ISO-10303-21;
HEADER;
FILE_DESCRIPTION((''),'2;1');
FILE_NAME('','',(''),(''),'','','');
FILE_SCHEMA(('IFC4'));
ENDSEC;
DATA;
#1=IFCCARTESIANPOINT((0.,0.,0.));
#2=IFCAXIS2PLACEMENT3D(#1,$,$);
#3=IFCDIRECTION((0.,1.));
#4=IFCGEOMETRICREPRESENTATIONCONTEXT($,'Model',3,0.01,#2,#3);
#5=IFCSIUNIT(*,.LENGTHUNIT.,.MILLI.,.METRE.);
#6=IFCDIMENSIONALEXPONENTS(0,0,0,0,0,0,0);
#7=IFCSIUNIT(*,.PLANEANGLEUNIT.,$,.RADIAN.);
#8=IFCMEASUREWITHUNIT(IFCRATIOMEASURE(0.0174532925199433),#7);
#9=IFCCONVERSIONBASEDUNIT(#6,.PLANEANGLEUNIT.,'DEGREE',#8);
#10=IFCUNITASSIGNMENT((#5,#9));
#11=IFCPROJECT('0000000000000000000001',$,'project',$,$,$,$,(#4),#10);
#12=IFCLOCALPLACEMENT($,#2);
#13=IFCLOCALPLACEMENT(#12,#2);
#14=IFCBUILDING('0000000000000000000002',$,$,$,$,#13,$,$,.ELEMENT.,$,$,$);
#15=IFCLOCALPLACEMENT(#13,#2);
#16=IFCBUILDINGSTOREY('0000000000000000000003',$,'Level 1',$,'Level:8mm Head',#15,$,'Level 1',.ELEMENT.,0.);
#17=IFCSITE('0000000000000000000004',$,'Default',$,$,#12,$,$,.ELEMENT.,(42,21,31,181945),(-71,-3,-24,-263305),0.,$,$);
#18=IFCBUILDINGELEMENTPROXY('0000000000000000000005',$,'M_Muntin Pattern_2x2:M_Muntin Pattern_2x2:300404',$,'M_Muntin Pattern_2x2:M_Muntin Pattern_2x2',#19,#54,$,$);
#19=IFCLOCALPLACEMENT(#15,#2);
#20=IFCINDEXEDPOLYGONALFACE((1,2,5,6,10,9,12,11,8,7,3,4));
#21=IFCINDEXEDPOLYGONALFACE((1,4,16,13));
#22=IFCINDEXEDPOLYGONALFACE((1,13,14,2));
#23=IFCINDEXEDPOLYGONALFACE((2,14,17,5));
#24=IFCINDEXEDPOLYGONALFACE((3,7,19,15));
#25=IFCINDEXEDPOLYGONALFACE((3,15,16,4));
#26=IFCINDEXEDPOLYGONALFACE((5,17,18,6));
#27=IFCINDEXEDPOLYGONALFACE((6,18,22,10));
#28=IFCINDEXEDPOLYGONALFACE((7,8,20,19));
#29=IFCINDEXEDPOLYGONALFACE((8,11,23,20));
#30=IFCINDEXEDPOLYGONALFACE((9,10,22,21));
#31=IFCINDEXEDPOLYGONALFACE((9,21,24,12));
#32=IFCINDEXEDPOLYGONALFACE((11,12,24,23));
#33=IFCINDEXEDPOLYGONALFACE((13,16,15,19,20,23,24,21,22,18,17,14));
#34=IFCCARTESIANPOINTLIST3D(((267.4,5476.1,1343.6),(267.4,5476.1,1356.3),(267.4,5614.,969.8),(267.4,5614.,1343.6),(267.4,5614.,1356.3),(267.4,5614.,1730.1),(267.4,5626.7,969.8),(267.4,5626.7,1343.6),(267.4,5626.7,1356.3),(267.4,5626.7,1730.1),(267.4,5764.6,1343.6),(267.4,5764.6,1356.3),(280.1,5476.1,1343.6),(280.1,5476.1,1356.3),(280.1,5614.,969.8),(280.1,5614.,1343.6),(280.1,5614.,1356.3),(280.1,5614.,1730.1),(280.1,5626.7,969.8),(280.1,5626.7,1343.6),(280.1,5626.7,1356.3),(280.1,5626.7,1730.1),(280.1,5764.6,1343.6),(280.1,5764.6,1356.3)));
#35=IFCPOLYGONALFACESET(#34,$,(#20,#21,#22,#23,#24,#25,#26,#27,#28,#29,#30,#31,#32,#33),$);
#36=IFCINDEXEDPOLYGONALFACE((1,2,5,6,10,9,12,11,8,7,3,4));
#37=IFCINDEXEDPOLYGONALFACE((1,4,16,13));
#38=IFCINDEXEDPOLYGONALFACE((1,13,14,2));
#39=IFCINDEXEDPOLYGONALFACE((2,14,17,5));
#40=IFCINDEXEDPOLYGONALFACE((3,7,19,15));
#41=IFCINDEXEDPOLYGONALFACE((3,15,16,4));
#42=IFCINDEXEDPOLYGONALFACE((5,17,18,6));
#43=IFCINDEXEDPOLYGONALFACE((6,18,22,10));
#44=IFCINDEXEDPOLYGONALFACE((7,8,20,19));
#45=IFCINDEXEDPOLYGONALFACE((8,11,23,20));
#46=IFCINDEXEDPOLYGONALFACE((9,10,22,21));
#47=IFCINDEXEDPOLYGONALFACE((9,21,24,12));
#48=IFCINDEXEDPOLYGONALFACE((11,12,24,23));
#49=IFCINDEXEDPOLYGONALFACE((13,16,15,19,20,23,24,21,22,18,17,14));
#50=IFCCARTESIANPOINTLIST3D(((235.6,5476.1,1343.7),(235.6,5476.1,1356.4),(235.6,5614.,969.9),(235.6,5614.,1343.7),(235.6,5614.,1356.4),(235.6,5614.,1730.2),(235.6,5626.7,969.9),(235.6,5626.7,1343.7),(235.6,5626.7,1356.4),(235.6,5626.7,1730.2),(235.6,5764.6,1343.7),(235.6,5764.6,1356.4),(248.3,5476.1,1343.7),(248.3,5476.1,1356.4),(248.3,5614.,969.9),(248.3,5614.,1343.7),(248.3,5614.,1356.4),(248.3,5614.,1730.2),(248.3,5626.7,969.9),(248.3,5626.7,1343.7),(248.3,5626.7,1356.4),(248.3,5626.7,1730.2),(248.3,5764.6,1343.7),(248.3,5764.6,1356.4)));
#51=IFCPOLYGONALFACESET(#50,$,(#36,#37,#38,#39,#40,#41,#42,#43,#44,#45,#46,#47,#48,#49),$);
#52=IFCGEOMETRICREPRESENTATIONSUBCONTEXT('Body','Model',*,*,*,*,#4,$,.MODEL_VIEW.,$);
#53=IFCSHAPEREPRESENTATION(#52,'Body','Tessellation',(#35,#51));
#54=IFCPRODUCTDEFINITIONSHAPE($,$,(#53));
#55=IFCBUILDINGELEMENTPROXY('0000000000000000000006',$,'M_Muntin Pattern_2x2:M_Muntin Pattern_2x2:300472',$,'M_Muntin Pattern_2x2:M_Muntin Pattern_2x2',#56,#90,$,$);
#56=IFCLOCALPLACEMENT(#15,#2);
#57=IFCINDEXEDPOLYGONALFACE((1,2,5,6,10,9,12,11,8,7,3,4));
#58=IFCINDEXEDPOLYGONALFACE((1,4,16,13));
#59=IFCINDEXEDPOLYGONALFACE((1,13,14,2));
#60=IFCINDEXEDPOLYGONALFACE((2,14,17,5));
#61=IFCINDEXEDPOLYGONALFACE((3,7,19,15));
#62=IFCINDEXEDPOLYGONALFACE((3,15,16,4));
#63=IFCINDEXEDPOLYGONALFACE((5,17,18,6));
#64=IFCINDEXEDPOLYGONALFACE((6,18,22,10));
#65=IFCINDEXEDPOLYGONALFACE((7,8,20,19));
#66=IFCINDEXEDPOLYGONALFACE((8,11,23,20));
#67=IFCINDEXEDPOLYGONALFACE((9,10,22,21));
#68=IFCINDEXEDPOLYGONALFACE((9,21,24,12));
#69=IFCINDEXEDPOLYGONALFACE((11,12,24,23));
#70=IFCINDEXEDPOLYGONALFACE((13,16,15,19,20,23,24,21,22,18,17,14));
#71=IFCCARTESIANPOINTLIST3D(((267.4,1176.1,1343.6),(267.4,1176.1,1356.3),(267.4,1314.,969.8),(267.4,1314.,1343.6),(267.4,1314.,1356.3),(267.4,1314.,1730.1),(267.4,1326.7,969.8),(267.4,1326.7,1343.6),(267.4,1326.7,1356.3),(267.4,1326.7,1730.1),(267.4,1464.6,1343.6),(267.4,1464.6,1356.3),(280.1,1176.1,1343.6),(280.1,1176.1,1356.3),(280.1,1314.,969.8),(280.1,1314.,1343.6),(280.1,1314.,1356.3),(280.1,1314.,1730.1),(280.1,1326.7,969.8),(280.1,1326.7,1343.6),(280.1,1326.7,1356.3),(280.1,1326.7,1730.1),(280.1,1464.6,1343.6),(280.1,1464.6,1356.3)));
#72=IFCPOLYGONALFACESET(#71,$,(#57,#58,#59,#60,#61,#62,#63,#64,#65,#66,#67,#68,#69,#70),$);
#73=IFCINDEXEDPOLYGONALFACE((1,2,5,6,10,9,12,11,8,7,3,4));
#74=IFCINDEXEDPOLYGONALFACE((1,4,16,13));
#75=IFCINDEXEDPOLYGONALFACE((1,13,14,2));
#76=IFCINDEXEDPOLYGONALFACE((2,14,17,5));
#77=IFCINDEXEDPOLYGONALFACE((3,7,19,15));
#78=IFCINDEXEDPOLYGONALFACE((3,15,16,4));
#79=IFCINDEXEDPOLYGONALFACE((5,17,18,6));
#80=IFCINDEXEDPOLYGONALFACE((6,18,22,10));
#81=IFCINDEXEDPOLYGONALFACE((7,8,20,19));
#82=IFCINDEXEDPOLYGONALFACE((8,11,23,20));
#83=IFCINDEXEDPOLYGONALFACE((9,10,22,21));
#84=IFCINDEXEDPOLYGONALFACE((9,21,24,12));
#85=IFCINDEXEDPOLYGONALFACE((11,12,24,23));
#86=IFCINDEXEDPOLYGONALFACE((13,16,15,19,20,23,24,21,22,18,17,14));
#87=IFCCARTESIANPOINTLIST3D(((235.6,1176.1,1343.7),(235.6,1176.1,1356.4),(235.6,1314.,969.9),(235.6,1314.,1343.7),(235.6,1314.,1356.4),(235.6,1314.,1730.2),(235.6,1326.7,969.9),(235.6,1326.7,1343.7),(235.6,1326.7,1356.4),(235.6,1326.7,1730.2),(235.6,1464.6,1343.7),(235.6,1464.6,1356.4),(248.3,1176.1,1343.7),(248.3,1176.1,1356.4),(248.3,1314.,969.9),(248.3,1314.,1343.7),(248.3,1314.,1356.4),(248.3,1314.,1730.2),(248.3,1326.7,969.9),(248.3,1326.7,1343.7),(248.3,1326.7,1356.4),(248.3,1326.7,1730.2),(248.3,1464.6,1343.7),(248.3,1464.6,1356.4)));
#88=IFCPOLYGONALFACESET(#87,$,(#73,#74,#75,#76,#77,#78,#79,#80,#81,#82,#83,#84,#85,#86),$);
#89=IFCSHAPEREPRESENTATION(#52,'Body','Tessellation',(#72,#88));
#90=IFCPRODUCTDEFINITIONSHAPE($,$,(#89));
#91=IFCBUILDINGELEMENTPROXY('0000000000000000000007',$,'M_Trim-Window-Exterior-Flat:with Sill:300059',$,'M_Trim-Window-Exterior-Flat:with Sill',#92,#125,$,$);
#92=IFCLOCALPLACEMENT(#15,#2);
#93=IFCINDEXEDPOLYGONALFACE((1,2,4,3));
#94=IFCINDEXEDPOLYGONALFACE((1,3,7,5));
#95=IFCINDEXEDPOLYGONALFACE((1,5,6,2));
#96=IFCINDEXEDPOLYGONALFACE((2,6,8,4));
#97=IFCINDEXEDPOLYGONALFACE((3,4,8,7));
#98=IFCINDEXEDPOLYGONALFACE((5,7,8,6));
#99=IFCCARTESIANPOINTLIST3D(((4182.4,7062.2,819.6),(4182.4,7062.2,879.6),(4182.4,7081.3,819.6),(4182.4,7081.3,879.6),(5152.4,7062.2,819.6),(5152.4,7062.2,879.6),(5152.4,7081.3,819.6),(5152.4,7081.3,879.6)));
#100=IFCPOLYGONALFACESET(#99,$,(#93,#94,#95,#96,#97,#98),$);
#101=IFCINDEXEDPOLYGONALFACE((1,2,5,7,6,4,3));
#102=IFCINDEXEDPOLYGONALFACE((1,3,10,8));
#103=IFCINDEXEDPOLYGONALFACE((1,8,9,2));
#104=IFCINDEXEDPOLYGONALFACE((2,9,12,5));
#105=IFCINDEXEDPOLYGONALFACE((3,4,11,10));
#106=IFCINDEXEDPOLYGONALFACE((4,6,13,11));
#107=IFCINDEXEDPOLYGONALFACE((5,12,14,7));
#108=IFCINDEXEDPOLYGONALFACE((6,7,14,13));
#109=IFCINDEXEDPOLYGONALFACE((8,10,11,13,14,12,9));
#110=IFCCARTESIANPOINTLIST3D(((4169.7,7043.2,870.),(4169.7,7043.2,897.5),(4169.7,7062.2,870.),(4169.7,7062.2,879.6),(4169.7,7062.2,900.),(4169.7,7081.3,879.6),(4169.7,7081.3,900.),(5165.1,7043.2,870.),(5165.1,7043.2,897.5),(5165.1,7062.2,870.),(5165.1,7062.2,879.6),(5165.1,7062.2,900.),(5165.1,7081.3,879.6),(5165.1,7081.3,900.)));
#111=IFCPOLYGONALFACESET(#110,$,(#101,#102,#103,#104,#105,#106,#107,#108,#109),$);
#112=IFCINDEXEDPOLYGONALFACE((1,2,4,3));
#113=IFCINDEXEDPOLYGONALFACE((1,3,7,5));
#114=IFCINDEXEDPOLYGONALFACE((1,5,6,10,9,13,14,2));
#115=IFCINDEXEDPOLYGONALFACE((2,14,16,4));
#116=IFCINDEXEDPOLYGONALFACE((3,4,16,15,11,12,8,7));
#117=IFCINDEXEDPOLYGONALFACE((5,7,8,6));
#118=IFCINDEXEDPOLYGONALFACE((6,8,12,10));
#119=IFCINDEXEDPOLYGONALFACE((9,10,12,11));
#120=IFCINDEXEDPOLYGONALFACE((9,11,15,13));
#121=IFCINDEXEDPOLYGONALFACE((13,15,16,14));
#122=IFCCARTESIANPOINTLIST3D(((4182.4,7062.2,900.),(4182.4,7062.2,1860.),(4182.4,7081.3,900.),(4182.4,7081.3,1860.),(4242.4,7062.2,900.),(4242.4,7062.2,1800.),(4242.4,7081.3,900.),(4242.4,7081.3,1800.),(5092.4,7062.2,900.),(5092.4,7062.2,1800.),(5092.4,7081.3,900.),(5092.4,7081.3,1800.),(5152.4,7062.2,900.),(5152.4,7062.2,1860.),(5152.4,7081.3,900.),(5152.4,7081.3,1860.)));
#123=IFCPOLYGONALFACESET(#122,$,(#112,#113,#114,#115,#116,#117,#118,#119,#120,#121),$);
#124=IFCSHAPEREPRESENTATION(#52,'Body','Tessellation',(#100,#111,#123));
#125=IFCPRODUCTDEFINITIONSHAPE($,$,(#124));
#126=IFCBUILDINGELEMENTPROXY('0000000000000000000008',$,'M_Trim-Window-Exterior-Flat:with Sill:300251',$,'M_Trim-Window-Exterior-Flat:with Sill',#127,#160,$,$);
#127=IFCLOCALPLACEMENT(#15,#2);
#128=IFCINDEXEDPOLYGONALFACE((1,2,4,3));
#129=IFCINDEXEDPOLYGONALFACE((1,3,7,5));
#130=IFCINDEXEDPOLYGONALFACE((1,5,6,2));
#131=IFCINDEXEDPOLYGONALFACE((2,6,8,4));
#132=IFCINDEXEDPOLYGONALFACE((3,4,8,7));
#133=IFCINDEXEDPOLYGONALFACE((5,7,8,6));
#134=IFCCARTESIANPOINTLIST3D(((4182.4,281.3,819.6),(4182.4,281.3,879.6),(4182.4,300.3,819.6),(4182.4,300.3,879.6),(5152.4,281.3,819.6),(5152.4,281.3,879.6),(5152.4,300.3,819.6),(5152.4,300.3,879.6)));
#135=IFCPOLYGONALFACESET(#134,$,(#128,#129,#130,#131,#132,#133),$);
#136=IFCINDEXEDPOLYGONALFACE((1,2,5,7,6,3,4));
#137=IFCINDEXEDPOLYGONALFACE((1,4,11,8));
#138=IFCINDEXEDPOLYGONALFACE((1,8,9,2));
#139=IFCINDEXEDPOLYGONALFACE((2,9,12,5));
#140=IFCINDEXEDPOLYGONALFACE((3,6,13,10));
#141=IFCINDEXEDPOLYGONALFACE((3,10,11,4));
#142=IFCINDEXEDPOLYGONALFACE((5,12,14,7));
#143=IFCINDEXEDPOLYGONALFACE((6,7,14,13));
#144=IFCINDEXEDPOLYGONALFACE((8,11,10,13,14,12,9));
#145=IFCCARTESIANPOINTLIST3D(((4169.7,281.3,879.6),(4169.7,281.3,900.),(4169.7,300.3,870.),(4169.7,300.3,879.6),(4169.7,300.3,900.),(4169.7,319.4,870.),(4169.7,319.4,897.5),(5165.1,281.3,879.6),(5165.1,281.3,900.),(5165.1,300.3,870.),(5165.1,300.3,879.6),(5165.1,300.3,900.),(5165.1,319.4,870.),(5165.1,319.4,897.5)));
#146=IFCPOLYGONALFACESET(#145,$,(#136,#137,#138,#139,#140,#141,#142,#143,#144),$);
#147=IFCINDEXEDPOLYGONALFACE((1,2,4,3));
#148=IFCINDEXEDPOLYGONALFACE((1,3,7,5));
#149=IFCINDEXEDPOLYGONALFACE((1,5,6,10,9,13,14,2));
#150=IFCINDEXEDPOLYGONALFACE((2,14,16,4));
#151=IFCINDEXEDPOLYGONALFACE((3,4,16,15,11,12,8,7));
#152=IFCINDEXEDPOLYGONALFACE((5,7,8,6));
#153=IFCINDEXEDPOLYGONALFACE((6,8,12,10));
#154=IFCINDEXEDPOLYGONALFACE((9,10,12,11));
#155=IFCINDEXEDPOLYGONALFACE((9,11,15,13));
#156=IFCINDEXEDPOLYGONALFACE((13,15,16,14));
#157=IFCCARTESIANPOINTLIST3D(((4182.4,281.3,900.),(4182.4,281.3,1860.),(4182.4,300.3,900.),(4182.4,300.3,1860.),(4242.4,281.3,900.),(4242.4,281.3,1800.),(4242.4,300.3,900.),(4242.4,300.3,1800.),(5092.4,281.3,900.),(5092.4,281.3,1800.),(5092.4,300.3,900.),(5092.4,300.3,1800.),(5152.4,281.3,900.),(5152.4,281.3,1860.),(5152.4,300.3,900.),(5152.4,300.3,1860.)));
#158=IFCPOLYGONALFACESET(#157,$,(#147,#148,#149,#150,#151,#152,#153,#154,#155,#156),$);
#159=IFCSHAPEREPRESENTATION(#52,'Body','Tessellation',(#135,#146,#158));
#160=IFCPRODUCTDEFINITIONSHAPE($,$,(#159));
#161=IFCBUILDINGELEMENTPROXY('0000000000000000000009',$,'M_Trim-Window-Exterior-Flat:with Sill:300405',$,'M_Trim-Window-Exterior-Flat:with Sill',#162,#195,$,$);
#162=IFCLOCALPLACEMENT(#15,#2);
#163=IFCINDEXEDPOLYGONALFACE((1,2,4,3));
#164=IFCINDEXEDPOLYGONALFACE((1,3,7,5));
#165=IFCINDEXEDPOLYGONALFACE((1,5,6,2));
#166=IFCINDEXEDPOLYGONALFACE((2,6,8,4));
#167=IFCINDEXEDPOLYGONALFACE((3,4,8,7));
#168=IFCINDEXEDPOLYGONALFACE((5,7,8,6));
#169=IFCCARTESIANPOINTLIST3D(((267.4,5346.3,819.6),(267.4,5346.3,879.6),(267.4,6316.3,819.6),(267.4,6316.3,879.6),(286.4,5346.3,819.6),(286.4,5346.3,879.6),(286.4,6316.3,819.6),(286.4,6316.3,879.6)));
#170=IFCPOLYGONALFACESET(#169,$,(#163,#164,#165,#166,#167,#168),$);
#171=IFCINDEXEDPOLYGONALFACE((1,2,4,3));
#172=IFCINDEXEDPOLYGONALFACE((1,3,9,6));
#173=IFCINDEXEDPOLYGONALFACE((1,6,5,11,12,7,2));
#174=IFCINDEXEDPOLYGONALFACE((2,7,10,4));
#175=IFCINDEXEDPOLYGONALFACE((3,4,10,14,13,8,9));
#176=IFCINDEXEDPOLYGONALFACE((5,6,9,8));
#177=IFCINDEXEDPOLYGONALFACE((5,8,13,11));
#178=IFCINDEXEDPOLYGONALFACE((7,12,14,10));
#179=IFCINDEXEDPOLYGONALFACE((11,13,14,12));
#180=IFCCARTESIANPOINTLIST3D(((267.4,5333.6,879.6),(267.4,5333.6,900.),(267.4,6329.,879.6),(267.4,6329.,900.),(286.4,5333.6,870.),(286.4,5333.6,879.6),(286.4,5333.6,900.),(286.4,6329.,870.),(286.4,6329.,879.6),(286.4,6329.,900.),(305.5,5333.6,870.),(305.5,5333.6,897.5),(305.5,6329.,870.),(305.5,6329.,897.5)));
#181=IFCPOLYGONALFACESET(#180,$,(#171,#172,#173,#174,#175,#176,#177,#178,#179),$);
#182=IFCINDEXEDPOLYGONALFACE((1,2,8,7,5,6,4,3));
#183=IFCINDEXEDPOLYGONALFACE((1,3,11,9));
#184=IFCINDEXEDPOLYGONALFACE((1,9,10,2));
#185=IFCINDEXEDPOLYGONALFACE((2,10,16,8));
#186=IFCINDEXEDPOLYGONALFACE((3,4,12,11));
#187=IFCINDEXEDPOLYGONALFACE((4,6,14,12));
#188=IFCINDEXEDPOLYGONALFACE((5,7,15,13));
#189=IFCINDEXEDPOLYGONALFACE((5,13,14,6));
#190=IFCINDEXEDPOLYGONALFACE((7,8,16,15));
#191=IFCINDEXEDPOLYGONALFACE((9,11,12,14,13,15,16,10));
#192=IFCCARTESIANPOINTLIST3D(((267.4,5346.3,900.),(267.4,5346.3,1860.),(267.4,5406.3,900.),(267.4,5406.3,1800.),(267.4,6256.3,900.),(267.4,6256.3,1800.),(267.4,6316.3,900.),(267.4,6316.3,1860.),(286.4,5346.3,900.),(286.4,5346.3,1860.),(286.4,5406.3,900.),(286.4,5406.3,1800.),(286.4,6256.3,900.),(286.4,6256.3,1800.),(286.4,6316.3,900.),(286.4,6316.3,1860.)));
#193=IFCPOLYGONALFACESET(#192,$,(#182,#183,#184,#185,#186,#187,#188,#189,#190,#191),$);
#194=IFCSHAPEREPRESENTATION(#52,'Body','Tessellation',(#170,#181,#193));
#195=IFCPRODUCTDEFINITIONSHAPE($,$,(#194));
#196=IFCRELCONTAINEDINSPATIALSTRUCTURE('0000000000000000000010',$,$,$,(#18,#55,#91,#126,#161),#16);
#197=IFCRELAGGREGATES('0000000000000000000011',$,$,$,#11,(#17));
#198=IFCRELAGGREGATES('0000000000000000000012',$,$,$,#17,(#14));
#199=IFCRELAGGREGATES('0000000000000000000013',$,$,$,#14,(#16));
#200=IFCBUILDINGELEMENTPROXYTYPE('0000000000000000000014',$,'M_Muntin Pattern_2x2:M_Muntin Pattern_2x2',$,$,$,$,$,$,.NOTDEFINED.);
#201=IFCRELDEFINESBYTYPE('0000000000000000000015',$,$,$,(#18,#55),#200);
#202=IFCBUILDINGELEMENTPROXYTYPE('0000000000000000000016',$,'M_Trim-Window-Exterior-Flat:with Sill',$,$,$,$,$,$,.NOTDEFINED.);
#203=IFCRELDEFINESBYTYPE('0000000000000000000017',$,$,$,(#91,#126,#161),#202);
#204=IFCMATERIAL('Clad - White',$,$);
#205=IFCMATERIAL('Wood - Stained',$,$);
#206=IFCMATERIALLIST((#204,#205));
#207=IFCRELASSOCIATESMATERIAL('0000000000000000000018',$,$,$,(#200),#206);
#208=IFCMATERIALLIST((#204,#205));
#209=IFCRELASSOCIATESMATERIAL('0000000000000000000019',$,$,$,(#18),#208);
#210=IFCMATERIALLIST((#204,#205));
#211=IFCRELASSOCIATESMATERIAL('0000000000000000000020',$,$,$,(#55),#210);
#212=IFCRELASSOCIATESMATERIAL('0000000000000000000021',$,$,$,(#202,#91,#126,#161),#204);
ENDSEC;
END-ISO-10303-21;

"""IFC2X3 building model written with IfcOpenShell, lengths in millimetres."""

from ifc_helpers import new_model, entity, si_unit, converted_unit, direction, frame, frame_2d, origin, place, context, subcontext, project, spatial, polyline, rectangle, outline, extrude, source, transform, mapped, material, material_list, type_object, type_shapes, element, save


model = new_model("IFC2X3")

# Units and contexts
model_context = context("Model", 3, precision=0.01, world=origin(), true_north=direction((0.0, 1.0)))
body_context = subcontext(model_context, "Body", "Model", "MODEL_VIEW")
ifc_project = project(units=[si_unit("LENGTHUNIT", "METRE", prefix="MILLI"), converted_unit("PLANEANGLEUNIT", "DEGREE", entity("IfcRatioMeasure", 0.0174532925199433), si_unit("PLANEANGLEUNIT", "RADIAN"), dimensions=[0, 0, 0, 0, 0, 0, 0])], contexts=[model_context])

# Site, building, storey
site_placement = place(None, origin())
site = spatial("IfcSite", under=ifc_project, at=site_placement, Name="Default", CompositionType="ELEMENT", RefLatitude=(42, 21, 31, 181945), RefLongitude=(-71, -3, -24, -263305), RefElevation=0.0)
building_placement = place(site_placement, origin())
building = spatial("IfcBuilding", under=site, at=building_placement, CompositionType="ELEMENT")
storey_placement = place(building_placement, origin())
storey = spatial("IfcBuildingStorey", under=building, at=storey_placement, Name="Level 1", ObjectType="Level:8mm Head", LongName="Level 1", CompositionType="ELEMENT", Elevation=0.0)

# Building element proxies
ifc_material_1 = material(Name="Clad - White")
ifc_material_2 = material(Name="Wood - Stained")
ifc_material_list_1 = material_list([ifc_material_1, ifc_material_2])
building_element_proxy_type_1 = type_object("IfcBuildingElementProxyType", Name="M_Muntin Pattern_2x2:M_Muntin Pattern_2x2", PredefinedType="NOTDEFINED", material=ifc_material_list_1)
shared_shape_1 = source(origin(), body_context, "Body", "SweptSolid", [
    extrude(outline(polyline([(6.4, -6.4), (380.1, -6.4), (380.1, 6.3), (6.4, 6.3), (6.4, 144.2), (-6.3, 144.2), (-6.3, 6.3), (-380.2, 6.3), (-380.2, -6.4), (-6.3, -6.4), (-6.3, -144.2), (6.4, -144.2), (6.4, -6.4)])), frame((0.0, -22.2, 380.1), z_axis=(0.0, 1.0, 0.0), x_axis=(0.0, 0.0, 1.0)), (0.0, 0.0, 1.0), 12.7),
    extrude(outline(polyline([(6.4, -6.4), (380.2, -6.4), (380.2, 6.3), (6.4, 6.3), (6.4, 144.2), (-6.3, 144.2), (-6.3, 6.3), (-380.2, 6.3), (-380.2, -6.4), (-6.3, -6.4), (-6.3, -144.2), (6.4, -144.2), (6.4, -6.4)])), frame((0.0, 9.5, 380.2), z_axis=(0.0, 1.0, 0.0), x_axis=(0.0, 0.0, 1.0)), (0.0, 0.0, 1.0), 12.7),
])
type_shapes(building_element_proxy_type_1, [shared_shape_1])
ifc_material_list_2 = material_list([ifc_material_1, ifc_material_2])
proxy_1_placement = place(storey_placement, frame((257.9, 5620.4, 969.9), z_axis=(0.0, 0.0, 1.0), x_axis=(0.0, 1.0, 0.0)))
element("IfcBuildingElementProxy", 1, at=proxy_1_placement, inside=storey, type_object=building_element_proxy_type_1, material=ifc_material_list_2, Name="M_Muntin Pattern_2x2:M_Muntin Pattern_2x2:300404", ObjectType="M_Muntin Pattern_2x2:M_Muntin Pattern_2x2", context=body_context, shape_type="MappedRepresentation", body=[
    mapped(shared_shape_1, transform((0.0, 0.0, 0.0), scale=1.0)),
])
ifc_material_list_3 = material_list([ifc_material_1, ifc_material_2])
proxy_2_placement = place(storey_placement, frame((257.9, 1320.4, 969.9), z_axis=(0.0, 0.0, 1.0), x_axis=(0.0, 1.0, 0.0)))
element("IfcBuildingElementProxy", 2, at=proxy_2_placement, inside=storey, type_object=building_element_proxy_type_1, material=ifc_material_list_3, Name="M_Muntin Pattern_2x2:M_Muntin Pattern_2x2:300472", ObjectType="M_Muntin Pattern_2x2:M_Muntin Pattern_2x2", context=body_context, shape_type="MappedRepresentation", body=[
    mapped(shared_shape_1, transform((0.0, 0.0, 0.0), scale=1.0)),
])
building_element_proxy_type_2 = type_object("IfcBuildingElementProxyType", Name="M_Trim-Window-Exterior-Flat:with Sill", PredefinedType="NOTDEFINED", material=ifc_material_1)
shared_shape_2 = source(origin(), body_context, "Body", "SweptSolid", [
    extrude(rectangle(XDim=970.0, YDim=60.0, at=frame_2d((0.0, 0.0), x_axis=(1.0, 0.0))), frame((0.0, -950.4, 0.0), z_axis=(0.0, 0.0, 1.0), x_axis=(-1.0, 0.0, 0.0)), (0.0, 0.0, 1.0), 19.1),
    extrude(outline(polyline([(-19.0, -15.2), (0.0, -15.2), (0.0, -5.7), (19.0, -5.7), (19.0, 14.8), (0.0, 14.8), (-19.0, 12.3), (-19.0, -15.2)])), frame((-497.7, -914.8, 19.0), z_axis=(1.0, 0.0, 0.0), x_axis=(0.0, 0.0, -1.0)), (0.0, 0.0, 1.0), 995.4),
    extrude(outline(polyline([(-495.0, -485.0), (465.0, -485.0), (465.0, -425.0), (-435.0, -425.0), (-435.0, 425.0), (465.0, 425.0), (465.0, 485.0), (-495.0, 485.0), (-495.0, -485.0)])), frame((0.0, -435.0, 0.0), z_axis=(0.0, 0.0, 1.0), x_axis=(0.0, -1.0, 0.0)), (0.0, 0.0, 1.0), 19.1),
])
type_shapes(building_element_proxy_type_2, [shared_shape_2])
for number, where, z_axis, x_axis, name in (
    (3, (4667.4, 7081.3, 1800.0), (0.0, -1.0, 0.0), (1.0, 0.0, 0.0), "M_Trim-Window-Exterior-Flat:with Sill:300059"),
    (4, (4667.4, 281.3, 1800.0), (0.0, 1.0, 0.0), (-1.0, 0.0, 0.0), "M_Trim-Window-Exterior-Flat:with Sill:300251"),
    (5, (267.4, 5831.3, 1800.0), (1.0, 0.0, 0.0), (0.0, 1.0, 0.0), "M_Trim-Window-Exterior-Flat:with Sill:300405"),
):
    element("IfcBuildingElementProxy", number, at=place(storey_placement, frame(where, z_axis=z_axis, x_axis=x_axis)), inside=storey, type_object=building_element_proxy_type_2, material=ifc_material_1, Name=name, ObjectType="M_Trim-Window-Exterior-Flat:with Sill", context=body_context, shape_type="MappedRepresentation", body=[
        mapped(shared_shape_2, transform((0.0, 0.0, 0.0), scale=1.0)),
    ])

save(model, "model.ifc")
